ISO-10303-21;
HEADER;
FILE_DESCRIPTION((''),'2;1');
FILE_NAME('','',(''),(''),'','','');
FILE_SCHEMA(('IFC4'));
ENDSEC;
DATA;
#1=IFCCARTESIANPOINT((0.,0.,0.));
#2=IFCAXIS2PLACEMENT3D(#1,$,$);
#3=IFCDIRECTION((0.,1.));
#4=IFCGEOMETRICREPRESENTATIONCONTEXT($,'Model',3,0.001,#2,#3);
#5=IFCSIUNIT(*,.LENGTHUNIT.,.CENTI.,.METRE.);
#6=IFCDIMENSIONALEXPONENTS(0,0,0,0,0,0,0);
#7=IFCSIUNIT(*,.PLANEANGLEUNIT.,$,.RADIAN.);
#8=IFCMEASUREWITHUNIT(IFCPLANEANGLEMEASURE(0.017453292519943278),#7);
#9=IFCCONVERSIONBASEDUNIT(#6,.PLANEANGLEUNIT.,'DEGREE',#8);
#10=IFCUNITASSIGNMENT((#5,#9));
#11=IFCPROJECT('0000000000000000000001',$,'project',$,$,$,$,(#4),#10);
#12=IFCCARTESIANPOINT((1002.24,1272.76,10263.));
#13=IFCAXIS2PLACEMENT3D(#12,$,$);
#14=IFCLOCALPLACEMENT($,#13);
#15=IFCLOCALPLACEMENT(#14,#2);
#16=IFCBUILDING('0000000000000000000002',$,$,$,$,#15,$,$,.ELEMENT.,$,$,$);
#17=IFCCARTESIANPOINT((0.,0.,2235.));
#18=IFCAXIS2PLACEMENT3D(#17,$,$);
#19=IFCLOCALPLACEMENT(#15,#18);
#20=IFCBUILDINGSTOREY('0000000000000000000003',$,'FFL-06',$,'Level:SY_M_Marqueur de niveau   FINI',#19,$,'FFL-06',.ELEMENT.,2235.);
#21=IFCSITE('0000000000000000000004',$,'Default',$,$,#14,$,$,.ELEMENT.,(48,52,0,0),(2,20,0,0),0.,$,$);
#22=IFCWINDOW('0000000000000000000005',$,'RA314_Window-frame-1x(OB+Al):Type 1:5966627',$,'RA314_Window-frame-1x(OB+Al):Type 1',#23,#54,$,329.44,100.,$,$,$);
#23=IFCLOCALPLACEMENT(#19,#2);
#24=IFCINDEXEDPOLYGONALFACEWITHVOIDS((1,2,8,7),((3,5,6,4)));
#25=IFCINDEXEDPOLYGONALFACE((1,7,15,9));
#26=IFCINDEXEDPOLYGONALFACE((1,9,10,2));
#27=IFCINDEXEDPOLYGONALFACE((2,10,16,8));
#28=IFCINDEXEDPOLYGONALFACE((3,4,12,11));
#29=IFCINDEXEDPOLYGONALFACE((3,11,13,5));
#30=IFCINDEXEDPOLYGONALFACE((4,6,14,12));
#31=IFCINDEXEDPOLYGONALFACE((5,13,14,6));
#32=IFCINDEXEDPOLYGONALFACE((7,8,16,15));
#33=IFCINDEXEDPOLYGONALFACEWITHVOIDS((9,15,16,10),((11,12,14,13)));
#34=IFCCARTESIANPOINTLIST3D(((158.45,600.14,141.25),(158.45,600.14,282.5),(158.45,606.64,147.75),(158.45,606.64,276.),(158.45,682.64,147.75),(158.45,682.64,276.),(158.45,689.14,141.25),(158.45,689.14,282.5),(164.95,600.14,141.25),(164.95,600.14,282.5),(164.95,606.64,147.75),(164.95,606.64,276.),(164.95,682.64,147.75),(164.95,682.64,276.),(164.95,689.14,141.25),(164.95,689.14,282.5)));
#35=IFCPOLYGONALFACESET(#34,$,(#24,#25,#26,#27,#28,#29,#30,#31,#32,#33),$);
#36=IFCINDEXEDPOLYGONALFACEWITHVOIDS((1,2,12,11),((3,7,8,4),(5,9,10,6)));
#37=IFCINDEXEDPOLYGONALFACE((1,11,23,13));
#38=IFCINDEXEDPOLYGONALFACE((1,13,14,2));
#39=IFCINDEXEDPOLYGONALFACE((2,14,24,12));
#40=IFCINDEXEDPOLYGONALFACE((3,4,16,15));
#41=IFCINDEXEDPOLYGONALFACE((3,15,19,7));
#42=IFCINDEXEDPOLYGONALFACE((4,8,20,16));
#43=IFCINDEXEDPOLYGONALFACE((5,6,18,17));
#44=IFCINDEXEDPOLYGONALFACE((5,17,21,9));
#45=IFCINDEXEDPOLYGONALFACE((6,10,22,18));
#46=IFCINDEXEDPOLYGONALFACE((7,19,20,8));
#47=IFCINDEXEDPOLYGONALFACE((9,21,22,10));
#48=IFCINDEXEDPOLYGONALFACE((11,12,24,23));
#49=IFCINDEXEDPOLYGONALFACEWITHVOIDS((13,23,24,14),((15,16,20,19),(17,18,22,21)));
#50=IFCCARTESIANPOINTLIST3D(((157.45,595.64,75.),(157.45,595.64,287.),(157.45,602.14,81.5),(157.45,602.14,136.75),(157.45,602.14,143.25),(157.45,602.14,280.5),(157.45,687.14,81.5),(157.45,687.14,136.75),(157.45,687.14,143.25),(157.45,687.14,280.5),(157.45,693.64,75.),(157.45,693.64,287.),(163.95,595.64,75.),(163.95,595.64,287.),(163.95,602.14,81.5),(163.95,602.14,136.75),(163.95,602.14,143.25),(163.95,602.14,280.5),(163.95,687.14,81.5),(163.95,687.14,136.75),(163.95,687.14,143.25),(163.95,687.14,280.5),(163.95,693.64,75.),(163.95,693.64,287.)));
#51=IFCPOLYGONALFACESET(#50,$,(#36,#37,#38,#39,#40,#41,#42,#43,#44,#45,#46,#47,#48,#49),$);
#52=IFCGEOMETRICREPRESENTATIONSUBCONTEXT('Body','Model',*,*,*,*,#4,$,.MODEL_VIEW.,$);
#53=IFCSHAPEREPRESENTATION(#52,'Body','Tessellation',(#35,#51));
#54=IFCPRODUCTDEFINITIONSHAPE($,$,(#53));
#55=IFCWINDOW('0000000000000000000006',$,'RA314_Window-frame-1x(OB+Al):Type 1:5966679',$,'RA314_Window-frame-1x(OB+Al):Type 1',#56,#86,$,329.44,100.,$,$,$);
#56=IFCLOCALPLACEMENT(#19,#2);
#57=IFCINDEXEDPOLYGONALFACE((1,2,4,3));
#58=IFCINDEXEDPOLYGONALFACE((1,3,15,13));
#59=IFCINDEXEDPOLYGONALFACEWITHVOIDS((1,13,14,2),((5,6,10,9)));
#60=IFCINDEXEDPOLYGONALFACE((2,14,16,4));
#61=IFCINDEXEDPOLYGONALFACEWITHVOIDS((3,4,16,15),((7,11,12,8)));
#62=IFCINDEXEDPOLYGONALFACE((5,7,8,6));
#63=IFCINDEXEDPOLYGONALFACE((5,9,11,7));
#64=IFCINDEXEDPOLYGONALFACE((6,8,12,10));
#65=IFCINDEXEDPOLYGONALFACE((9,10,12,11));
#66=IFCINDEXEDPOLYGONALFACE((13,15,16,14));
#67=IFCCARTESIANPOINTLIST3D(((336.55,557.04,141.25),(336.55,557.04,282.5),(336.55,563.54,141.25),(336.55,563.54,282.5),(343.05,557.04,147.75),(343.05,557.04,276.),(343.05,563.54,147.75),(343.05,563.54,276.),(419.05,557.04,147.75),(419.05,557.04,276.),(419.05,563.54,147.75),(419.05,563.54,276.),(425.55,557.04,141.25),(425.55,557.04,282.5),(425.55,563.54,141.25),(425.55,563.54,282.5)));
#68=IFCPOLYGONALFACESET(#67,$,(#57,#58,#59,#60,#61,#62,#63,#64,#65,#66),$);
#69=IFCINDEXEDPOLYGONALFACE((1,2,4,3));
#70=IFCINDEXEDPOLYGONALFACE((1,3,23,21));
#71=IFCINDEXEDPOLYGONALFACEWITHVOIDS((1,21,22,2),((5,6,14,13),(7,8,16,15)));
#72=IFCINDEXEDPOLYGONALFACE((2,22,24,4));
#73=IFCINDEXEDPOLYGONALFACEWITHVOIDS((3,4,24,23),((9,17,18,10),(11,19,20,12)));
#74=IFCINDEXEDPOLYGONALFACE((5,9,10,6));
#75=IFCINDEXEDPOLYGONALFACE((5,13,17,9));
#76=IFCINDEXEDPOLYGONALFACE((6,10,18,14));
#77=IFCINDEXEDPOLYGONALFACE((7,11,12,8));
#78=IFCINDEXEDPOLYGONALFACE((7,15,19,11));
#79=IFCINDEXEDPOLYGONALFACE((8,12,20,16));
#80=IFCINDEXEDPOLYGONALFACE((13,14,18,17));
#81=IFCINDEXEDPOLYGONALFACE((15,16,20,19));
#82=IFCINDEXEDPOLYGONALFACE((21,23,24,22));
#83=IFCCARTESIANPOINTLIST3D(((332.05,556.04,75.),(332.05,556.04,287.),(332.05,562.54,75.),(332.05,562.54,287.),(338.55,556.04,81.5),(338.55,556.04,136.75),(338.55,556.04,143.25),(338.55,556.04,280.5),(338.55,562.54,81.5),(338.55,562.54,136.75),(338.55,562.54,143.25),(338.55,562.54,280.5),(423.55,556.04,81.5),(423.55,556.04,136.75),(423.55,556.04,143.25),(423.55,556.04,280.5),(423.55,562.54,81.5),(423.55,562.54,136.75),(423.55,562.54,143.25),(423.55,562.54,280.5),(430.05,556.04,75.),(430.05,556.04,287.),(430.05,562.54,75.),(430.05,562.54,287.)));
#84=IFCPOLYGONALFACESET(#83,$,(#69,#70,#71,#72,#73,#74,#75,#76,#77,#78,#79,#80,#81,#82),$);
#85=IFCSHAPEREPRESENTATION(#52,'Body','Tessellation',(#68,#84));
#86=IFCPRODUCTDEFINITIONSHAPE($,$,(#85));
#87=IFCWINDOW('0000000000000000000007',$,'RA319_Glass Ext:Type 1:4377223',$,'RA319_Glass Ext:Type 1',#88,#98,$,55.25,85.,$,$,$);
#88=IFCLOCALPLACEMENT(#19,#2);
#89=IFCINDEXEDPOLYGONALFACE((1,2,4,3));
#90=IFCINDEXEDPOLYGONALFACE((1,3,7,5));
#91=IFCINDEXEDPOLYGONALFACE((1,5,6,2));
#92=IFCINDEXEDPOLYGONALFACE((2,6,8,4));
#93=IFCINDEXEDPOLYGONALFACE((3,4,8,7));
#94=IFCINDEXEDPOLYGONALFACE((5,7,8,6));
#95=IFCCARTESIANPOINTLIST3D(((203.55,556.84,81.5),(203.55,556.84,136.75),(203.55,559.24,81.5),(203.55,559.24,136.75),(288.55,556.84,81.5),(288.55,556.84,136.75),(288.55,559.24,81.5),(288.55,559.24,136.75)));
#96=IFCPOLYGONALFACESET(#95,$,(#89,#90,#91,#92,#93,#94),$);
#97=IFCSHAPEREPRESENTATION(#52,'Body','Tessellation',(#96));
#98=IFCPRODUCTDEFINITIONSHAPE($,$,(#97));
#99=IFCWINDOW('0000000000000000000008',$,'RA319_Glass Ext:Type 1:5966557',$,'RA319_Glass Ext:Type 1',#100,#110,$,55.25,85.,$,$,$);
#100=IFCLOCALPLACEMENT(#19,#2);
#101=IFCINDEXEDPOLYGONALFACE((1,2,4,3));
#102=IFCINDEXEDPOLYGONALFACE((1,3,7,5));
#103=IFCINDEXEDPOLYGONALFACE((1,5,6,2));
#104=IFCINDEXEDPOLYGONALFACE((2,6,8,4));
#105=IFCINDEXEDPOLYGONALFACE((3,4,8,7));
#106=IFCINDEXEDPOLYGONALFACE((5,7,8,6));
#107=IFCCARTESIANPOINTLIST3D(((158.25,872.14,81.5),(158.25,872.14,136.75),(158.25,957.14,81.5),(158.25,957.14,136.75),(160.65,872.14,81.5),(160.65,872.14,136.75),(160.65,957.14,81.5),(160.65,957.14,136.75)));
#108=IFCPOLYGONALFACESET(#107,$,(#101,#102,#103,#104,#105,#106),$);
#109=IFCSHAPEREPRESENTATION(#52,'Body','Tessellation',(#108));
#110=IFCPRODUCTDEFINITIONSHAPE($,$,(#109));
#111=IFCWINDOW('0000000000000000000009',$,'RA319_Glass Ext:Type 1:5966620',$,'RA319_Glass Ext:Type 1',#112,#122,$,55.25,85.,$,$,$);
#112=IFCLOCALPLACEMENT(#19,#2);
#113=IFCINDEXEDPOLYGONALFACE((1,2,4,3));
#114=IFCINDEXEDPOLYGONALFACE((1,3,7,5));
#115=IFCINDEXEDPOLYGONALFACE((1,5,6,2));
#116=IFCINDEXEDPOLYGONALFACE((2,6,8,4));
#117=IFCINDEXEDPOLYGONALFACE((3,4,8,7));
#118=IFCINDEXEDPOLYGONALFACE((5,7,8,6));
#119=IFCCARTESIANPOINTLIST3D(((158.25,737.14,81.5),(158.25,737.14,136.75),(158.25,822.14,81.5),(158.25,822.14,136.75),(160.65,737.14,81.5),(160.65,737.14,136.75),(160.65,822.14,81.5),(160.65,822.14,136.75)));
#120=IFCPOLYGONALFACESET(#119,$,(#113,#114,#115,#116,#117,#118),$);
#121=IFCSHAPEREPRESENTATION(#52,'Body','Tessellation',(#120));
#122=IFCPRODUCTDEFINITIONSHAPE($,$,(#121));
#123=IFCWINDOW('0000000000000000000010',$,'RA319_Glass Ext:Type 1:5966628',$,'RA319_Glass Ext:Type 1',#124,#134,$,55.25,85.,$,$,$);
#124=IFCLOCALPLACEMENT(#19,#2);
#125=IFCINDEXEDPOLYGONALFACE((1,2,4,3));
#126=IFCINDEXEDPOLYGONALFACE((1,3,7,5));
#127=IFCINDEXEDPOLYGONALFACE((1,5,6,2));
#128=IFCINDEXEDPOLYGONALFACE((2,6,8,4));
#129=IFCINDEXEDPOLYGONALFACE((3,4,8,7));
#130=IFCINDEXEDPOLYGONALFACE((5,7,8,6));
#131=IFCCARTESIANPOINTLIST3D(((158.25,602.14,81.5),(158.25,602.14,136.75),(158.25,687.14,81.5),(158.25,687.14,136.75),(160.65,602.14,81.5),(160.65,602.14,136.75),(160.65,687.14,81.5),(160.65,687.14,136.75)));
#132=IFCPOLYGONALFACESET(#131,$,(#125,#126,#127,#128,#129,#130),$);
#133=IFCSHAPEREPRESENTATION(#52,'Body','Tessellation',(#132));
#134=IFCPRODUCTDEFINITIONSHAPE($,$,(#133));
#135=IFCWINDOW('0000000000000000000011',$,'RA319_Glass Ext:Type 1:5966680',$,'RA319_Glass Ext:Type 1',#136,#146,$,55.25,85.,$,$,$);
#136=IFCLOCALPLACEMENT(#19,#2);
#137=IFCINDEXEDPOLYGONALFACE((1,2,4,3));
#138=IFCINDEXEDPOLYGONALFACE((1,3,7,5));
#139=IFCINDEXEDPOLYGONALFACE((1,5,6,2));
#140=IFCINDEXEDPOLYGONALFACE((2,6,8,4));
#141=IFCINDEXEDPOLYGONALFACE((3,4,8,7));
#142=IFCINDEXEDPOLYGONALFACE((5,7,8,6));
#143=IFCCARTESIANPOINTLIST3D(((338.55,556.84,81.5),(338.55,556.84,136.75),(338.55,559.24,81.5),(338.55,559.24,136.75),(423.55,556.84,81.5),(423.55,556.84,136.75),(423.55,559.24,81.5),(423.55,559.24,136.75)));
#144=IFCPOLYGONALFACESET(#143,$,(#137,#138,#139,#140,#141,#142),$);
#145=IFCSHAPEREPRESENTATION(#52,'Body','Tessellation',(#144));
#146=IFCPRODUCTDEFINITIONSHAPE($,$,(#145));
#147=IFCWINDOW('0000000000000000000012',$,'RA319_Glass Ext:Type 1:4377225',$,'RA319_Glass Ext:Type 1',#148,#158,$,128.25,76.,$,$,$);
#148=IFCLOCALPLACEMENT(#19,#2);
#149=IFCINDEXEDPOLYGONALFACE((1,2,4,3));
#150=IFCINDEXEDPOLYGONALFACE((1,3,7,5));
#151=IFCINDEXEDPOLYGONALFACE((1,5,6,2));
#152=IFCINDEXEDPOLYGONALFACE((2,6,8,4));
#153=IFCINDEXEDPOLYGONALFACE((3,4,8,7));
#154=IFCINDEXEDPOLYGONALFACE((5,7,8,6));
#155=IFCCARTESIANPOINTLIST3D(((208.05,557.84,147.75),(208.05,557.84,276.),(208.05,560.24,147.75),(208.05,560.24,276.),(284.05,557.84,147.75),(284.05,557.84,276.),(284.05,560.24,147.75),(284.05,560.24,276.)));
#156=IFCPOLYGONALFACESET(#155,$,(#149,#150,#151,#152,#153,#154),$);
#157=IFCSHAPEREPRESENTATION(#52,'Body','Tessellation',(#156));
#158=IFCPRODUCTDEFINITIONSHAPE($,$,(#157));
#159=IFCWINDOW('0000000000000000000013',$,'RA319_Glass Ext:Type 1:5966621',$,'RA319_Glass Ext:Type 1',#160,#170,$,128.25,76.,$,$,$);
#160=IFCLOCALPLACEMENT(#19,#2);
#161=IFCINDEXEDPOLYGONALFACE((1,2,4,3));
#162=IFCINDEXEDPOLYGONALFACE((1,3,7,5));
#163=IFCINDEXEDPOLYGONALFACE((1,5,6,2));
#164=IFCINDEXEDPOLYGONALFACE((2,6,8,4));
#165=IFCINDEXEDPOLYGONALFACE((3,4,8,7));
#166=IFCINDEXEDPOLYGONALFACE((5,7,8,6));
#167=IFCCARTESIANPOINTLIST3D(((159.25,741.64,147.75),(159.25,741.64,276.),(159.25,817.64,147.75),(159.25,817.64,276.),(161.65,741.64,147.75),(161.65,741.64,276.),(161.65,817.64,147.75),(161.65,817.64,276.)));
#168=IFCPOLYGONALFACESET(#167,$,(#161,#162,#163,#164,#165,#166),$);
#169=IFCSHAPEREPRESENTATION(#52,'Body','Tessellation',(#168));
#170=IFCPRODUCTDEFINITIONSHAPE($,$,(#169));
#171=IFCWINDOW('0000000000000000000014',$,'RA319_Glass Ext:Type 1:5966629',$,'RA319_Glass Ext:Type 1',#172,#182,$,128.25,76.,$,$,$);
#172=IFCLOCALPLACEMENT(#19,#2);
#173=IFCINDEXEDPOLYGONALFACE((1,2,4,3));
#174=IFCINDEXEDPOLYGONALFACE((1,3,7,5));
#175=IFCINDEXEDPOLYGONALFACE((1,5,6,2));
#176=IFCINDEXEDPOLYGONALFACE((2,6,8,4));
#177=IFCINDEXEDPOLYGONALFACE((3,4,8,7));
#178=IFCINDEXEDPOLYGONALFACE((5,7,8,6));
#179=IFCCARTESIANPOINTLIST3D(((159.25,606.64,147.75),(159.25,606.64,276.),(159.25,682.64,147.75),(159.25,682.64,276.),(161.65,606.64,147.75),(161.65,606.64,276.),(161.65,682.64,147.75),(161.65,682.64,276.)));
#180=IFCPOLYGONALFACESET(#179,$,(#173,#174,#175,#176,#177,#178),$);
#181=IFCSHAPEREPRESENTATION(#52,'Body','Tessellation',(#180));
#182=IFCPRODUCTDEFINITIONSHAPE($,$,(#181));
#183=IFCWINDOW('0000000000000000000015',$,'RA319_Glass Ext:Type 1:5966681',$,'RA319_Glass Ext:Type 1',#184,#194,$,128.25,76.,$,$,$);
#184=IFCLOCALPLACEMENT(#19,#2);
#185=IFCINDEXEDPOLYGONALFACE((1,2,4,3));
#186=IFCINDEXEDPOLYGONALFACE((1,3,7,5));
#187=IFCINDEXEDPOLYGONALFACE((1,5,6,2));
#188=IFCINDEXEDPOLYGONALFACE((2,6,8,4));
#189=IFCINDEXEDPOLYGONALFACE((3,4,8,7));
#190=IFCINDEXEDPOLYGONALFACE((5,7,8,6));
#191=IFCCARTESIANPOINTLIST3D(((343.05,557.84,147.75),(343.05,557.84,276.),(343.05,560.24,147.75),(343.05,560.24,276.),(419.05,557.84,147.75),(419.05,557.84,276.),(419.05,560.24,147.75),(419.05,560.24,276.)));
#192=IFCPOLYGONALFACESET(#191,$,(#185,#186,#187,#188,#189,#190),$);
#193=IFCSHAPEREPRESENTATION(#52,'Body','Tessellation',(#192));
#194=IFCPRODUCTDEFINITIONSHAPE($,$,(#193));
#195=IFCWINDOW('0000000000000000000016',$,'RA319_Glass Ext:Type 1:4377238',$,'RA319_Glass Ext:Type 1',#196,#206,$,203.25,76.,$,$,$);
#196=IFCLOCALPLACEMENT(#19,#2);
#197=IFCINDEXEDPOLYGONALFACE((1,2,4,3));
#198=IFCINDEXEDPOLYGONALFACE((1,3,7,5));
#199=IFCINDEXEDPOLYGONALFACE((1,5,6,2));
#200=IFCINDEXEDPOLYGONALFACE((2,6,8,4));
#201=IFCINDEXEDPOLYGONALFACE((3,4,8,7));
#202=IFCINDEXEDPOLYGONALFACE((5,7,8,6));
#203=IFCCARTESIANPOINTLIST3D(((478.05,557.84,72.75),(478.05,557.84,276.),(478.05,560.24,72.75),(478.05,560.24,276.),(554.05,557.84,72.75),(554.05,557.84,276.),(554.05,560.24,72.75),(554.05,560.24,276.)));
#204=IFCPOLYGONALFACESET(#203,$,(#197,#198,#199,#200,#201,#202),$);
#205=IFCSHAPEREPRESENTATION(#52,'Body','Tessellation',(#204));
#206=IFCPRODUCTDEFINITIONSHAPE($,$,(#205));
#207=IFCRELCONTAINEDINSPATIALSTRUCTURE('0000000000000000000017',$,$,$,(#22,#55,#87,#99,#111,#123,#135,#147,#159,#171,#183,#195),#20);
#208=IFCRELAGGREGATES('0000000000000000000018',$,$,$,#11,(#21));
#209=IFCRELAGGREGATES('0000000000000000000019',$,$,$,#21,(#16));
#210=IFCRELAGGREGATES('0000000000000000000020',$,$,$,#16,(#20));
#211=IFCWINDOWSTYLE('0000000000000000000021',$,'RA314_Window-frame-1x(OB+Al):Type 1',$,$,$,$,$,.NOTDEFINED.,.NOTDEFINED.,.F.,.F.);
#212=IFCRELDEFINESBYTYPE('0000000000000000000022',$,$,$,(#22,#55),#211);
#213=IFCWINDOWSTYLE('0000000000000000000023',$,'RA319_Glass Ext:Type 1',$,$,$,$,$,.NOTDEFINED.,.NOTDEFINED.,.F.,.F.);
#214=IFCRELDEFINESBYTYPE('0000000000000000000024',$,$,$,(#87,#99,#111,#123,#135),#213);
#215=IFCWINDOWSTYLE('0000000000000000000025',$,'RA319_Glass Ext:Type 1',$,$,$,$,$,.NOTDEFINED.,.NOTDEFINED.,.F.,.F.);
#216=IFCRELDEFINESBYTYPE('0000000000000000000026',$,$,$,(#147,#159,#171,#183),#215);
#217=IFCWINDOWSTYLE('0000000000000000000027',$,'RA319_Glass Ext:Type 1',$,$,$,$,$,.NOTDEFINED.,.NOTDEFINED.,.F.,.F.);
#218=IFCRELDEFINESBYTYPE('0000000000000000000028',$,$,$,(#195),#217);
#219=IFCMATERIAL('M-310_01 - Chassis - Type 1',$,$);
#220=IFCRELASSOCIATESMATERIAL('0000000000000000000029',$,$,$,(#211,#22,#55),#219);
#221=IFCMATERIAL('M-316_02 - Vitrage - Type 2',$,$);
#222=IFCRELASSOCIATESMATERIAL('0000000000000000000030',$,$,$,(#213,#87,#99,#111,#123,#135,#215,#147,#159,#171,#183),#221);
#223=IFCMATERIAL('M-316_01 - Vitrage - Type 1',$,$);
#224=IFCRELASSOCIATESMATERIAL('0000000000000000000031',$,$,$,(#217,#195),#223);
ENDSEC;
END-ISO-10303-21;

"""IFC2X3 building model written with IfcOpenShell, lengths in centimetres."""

from ifc_helpers import new_model, entity, si_unit, converted_unit, direction, frame, frame_2d, origin, place, context, subcontext, project, spatial, polyline, rectangle, outline, extrude, source, transform, mapped, material, type_object, type_shapes, element, save


model = new_model("IFC2X3")

# Units and contexts
model_context = context("Model", 3, precision=0.001, world=origin(), true_north=direction((0.0, 1.0)))
body_context = subcontext(model_context, "Body", "Model", "MODEL_VIEW")
ifc_project = project(units=[si_unit("LENGTHUNIT", "METRE", prefix="CENTI"), converted_unit("PLANEANGLEUNIT", "DEGREE", entity("IfcPlaneAngleMeasure", 0.017453292519943278), si_unit("PLANEANGLEUNIT", "RADIAN"), dimensions=[0, 0, 0, 0, 0, 0, 0])], contexts=[model_context])

# Site, building, storey
site_placement = place(None, frame((1002.24, 1272.76, 10263.0)))
site = spatial("IfcSite", under=ifc_project, at=site_placement, Name="Default", CompositionType="ELEMENT", RefLatitude=(48, 52, 0, 0), RefLongitude=(2, 20, 0, 0), RefElevation=0.0)
building_placement = place(site_placement, origin())
building = spatial("IfcBuilding", under=site, at=building_placement, CompositionType="ELEMENT")
storey_placement = place(building_placement, frame((0.0, 0.0, 2235.0)))
storey = spatial("IfcBuildingStorey", under=building, at=storey_placement, Name="FFL-06", ObjectType="Level:SY_M_Marqueur de niveau   FINI", LongName="FFL-06", CompositionType="ELEMENT", Elevation=2235.0)

# Shared definitions
ifc_material_1 = material(Name="M-316_02 - Vitrage - Type 2")

# Windows
ifc_material_2 = material(Name="M-316_01 - Vitrage - Type 1")
ifc_material_3 = material(Name="M-310_01 - Chassis - Type 1")
window_style_1 = type_object("IfcWindowStyle", Name="RA314_Window-frame-1x(OB+Al):Type 1", ConstructionType="NOTDEFINED", OperationType="NOTDEFINED", ParameterTakesPrecedence=False, Sizeable=False, material=ifc_material_3)
shared_shape_1 = source(origin(), body_context, "Body", "SweptSolid", [
    extrude(outline(polyline([(-70.62, -44.5), (70.62, -44.5), (70.62, 44.5), (-70.62, 44.5), (-70.62, -44.5)]), holes=[polyline([(-64.12, -38.0), (-64.12, 38.0), (64.12, 38.0), (64.12, -38.0), (-64.12, -38.0)])]), frame((0.0, -7.5, 136.87), z_axis=(0.0, 1.0, 0.0), x_axis=(0.0, 0.0, -1.0)), (0.0, 0.0, 1.0), 6.5),
    extrude(outline(polyline([(-106.0, -49.0), (106.0, -49.0), (106.0, 49.0), (-106.0, 49.0), (-106.0, -49.0)]), holes=[polyline([(-99.5, -42.5), (-99.5, 42.5), (37.75, 42.5), (37.75, -42.5), (-99.5, -42.5)]), polyline([(44.25, -42.5), (44.25, 42.5), (99.5, 42.5), (99.5, -42.5), (44.25, -42.5)])]), frame((0.0, -6.5, 106.0), z_axis=(0.0, 1.0, 0.0), x_axis=(0.0, 0.0, -1.0)), (0.0, 0.0, 1.0), 6.5),
])
type_shapes(window_style_1, [shared_shape_1])
for number, where, z_axis, x_axis, name in (
    (1, (157.45, 644.64, 75.0), (0.0, 0.0, 1.0), (0.0, 1.0, 0.0), "RA314_Window-frame-1x(OB+Al):Type 1:5966627"),
    (2, (381.05, 556.04, 75.0), (0.0, 0.0, 1.0), (-1.0, 0.0, 0.0), "RA314_Window-frame-1x(OB+Al):Type 1:5966679"),
):
    element("IfcWindow", number, at=place(storey_placement, frame(where, z_axis=z_axis, x_axis=x_axis)), inside=storey, type_object=window_style_1, material=ifc_material_3, Name=name, ObjectType="RA314_Window-frame-1x(OB+Al):Type 1", OverallHeight=329.44, OverallWidth=100.0, context=body_context, shape_type="MappedRepresentation", body=[
        mapped(shared_shape_1, transform((0.0, 0.0, 0.0), scale=1.0)),
    ])
window_style_2 = type_object("IfcWindowStyle", Name="RA319_Glass Ext:Type 1", ConstructionType="NOTDEFINED", OperationType="NOTDEFINED", ParameterTakesPrecedence=False, Sizeable=False, material=ifc_material_1)
shared_shape_2 = source(origin(), body_context, "Body", "SweptSolid", [
    extrude(rectangle(XDim=55.25, YDim=85.0, at=frame_2d((0.0, 0.0), x_axis=(1.0, 0.0))), frame((0.0, 0.0, 0.0), z_axis=(0.0, 0.0, 1.0), x_axis=(0.0, 1.0, 0.0)), (0.0, 0.0, 1.0), 2.4),
])
type_shapes(window_style_2, [shared_shape_2])
for number, where, z_axis, x_axis, name in (
    (3, (246.05, 556.84, 109.12), (0.0, 1.0, 0.0), (1.0, 0.0, 0.0), "RA319_Glass Ext:Type 1:4377223"),
    (4, (158.25, 914.64, 109.12), (1.0, 0.0, 0.0), (0.0, -1.0, 0.0), "RA319_Glass Ext:Type 1:5966557"),
    (5, (158.25, 779.64, 109.12), (1.0, 0.0, 0.0), (0.0, -1.0, 0.0), "RA319_Glass Ext:Type 1:5966620"),
    (6, (158.25, 644.64, 109.12), (1.0, 0.0, 0.0), (0.0, -1.0, 0.0), "RA319_Glass Ext:Type 1:5966628"),
    (7, (381.05, 556.84, 109.12), (0.0, 1.0, 0.0), (1.0, 0.0, 0.0), "RA319_Glass Ext:Type 1:5966680"),
):
    element("IfcWindow", number, at=place(storey_placement, frame(where, z_axis=z_axis, x_axis=x_axis)), inside=storey, type_object=window_style_2, material=ifc_material_1, Name=name, ObjectType="RA319_Glass Ext:Type 1", OverallHeight=55.25, OverallWidth=85.0, context=body_context, shape_type="MappedRepresentation", body=[
        mapped(shared_shape_2, transform((0.0, 0.0, 0.0), scale=1.0)),
    ])
window_style_3 = type_object("IfcWindowStyle", Name="RA319_Glass Ext:Type 1", ConstructionType="NOTDEFINED", OperationType="NOTDEFINED", ParameterTakesPrecedence=False, Sizeable=False, material=ifc_material_1)
shared_shape_3 = source(origin(), body_context, "Body", "SweptSolid", [
    extrude(rectangle(XDim=128.25, YDim=76.0, at=frame_2d((0.0, 0.0), x_axis=(1.0, 0.0))), frame((0.0, 0.0, 0.0), z_axis=(0.0, 0.0, 1.0), x_axis=(0.0, 1.0, 0.0)), (0.0, 0.0, 1.0), 2.4),
])
type_shapes(window_style_3, [shared_shape_3])
for number, where, z_axis, x_axis, name in (
    (8, (246.05, 557.84, 211.87), (0.0, 1.0, 0.0), (1.0, 0.0, 0.0), "RA319_Glass Ext:Type 1:4377225"),
    (9, (159.25, 779.64, 211.87), (1.0, 0.0, 0.0), (0.0, -1.0, 0.0), "RA319_Glass Ext:Type 1:5966621"),
    (10, (159.25, 644.64, 211.87), (1.0, 0.0, 0.0), (0.0, -1.0, 0.0), "RA319_Glass Ext:Type 1:5966629"),
    (11, (381.05, 557.84, 211.87), (0.0, 1.0, 0.0), (1.0, 0.0, 0.0), "RA319_Glass Ext:Type 1:5966681"),
):
    element("IfcWindow", number, at=place(storey_placement, frame(where, z_axis=z_axis, x_axis=x_axis)), inside=storey, type_object=window_style_3, material=ifc_material_1, Name=name, ObjectType="RA319_Glass Ext:Type 1", OverallHeight=128.25, OverallWidth=76.0, context=body_context, shape_type="MappedRepresentation", body=[
        mapped(shared_shape_3, transform((0.0, 0.0, 0.0), scale=1.0)),
    ])
window_style_4 = type_object("IfcWindowStyle", Name="RA319_Glass Ext:Type 1", ConstructionType="NOTDEFINED", OperationType="NOTDEFINED", ParameterTakesPrecedence=False, Sizeable=False, material=ifc_material_2)
shared_shape_4 = source(origin(), body_context, "Body", "SweptSolid", [
    extrude(rectangle(XDim=76.0, YDim=203.25, at=frame_2d((0.0, 0.0), x_axis=(1.0, 0.0))), frame((0.0, 0.0, 0.0), z_axis=(0.0, 0.0, 1.0), x_axis=(-1.0, 0.0, 0.0)), (0.0, 0.0, 1.0), 2.4),
])
type_shapes(window_style_4, [shared_shape_4])
for number, where, z_axis, x_axis, name in (
    (12, (516.05, 557.84, 174.37), (0.0, 1.0, 0.0), (-1.0, 0.0, 0.0), "RA319_Glass Ext:Type 1:4377238"),
):
    element("IfcWindow", number, at=place(storey_placement, frame(where, z_axis=z_axis, x_axis=x_axis)), inside=storey, type_object=window_style_4, material=ifc_material_2, Name=name, ObjectType="RA319_Glass Ext:Type 1", OverallHeight=203.25, OverallWidth=76.0, context=body_context, shape_type="MappedRepresentation", body=[
        mapped(shared_shape_4, transform((0.0, 0.0, 0.0), scale=1.0)),
    ])

save(model, "model.ifc")
